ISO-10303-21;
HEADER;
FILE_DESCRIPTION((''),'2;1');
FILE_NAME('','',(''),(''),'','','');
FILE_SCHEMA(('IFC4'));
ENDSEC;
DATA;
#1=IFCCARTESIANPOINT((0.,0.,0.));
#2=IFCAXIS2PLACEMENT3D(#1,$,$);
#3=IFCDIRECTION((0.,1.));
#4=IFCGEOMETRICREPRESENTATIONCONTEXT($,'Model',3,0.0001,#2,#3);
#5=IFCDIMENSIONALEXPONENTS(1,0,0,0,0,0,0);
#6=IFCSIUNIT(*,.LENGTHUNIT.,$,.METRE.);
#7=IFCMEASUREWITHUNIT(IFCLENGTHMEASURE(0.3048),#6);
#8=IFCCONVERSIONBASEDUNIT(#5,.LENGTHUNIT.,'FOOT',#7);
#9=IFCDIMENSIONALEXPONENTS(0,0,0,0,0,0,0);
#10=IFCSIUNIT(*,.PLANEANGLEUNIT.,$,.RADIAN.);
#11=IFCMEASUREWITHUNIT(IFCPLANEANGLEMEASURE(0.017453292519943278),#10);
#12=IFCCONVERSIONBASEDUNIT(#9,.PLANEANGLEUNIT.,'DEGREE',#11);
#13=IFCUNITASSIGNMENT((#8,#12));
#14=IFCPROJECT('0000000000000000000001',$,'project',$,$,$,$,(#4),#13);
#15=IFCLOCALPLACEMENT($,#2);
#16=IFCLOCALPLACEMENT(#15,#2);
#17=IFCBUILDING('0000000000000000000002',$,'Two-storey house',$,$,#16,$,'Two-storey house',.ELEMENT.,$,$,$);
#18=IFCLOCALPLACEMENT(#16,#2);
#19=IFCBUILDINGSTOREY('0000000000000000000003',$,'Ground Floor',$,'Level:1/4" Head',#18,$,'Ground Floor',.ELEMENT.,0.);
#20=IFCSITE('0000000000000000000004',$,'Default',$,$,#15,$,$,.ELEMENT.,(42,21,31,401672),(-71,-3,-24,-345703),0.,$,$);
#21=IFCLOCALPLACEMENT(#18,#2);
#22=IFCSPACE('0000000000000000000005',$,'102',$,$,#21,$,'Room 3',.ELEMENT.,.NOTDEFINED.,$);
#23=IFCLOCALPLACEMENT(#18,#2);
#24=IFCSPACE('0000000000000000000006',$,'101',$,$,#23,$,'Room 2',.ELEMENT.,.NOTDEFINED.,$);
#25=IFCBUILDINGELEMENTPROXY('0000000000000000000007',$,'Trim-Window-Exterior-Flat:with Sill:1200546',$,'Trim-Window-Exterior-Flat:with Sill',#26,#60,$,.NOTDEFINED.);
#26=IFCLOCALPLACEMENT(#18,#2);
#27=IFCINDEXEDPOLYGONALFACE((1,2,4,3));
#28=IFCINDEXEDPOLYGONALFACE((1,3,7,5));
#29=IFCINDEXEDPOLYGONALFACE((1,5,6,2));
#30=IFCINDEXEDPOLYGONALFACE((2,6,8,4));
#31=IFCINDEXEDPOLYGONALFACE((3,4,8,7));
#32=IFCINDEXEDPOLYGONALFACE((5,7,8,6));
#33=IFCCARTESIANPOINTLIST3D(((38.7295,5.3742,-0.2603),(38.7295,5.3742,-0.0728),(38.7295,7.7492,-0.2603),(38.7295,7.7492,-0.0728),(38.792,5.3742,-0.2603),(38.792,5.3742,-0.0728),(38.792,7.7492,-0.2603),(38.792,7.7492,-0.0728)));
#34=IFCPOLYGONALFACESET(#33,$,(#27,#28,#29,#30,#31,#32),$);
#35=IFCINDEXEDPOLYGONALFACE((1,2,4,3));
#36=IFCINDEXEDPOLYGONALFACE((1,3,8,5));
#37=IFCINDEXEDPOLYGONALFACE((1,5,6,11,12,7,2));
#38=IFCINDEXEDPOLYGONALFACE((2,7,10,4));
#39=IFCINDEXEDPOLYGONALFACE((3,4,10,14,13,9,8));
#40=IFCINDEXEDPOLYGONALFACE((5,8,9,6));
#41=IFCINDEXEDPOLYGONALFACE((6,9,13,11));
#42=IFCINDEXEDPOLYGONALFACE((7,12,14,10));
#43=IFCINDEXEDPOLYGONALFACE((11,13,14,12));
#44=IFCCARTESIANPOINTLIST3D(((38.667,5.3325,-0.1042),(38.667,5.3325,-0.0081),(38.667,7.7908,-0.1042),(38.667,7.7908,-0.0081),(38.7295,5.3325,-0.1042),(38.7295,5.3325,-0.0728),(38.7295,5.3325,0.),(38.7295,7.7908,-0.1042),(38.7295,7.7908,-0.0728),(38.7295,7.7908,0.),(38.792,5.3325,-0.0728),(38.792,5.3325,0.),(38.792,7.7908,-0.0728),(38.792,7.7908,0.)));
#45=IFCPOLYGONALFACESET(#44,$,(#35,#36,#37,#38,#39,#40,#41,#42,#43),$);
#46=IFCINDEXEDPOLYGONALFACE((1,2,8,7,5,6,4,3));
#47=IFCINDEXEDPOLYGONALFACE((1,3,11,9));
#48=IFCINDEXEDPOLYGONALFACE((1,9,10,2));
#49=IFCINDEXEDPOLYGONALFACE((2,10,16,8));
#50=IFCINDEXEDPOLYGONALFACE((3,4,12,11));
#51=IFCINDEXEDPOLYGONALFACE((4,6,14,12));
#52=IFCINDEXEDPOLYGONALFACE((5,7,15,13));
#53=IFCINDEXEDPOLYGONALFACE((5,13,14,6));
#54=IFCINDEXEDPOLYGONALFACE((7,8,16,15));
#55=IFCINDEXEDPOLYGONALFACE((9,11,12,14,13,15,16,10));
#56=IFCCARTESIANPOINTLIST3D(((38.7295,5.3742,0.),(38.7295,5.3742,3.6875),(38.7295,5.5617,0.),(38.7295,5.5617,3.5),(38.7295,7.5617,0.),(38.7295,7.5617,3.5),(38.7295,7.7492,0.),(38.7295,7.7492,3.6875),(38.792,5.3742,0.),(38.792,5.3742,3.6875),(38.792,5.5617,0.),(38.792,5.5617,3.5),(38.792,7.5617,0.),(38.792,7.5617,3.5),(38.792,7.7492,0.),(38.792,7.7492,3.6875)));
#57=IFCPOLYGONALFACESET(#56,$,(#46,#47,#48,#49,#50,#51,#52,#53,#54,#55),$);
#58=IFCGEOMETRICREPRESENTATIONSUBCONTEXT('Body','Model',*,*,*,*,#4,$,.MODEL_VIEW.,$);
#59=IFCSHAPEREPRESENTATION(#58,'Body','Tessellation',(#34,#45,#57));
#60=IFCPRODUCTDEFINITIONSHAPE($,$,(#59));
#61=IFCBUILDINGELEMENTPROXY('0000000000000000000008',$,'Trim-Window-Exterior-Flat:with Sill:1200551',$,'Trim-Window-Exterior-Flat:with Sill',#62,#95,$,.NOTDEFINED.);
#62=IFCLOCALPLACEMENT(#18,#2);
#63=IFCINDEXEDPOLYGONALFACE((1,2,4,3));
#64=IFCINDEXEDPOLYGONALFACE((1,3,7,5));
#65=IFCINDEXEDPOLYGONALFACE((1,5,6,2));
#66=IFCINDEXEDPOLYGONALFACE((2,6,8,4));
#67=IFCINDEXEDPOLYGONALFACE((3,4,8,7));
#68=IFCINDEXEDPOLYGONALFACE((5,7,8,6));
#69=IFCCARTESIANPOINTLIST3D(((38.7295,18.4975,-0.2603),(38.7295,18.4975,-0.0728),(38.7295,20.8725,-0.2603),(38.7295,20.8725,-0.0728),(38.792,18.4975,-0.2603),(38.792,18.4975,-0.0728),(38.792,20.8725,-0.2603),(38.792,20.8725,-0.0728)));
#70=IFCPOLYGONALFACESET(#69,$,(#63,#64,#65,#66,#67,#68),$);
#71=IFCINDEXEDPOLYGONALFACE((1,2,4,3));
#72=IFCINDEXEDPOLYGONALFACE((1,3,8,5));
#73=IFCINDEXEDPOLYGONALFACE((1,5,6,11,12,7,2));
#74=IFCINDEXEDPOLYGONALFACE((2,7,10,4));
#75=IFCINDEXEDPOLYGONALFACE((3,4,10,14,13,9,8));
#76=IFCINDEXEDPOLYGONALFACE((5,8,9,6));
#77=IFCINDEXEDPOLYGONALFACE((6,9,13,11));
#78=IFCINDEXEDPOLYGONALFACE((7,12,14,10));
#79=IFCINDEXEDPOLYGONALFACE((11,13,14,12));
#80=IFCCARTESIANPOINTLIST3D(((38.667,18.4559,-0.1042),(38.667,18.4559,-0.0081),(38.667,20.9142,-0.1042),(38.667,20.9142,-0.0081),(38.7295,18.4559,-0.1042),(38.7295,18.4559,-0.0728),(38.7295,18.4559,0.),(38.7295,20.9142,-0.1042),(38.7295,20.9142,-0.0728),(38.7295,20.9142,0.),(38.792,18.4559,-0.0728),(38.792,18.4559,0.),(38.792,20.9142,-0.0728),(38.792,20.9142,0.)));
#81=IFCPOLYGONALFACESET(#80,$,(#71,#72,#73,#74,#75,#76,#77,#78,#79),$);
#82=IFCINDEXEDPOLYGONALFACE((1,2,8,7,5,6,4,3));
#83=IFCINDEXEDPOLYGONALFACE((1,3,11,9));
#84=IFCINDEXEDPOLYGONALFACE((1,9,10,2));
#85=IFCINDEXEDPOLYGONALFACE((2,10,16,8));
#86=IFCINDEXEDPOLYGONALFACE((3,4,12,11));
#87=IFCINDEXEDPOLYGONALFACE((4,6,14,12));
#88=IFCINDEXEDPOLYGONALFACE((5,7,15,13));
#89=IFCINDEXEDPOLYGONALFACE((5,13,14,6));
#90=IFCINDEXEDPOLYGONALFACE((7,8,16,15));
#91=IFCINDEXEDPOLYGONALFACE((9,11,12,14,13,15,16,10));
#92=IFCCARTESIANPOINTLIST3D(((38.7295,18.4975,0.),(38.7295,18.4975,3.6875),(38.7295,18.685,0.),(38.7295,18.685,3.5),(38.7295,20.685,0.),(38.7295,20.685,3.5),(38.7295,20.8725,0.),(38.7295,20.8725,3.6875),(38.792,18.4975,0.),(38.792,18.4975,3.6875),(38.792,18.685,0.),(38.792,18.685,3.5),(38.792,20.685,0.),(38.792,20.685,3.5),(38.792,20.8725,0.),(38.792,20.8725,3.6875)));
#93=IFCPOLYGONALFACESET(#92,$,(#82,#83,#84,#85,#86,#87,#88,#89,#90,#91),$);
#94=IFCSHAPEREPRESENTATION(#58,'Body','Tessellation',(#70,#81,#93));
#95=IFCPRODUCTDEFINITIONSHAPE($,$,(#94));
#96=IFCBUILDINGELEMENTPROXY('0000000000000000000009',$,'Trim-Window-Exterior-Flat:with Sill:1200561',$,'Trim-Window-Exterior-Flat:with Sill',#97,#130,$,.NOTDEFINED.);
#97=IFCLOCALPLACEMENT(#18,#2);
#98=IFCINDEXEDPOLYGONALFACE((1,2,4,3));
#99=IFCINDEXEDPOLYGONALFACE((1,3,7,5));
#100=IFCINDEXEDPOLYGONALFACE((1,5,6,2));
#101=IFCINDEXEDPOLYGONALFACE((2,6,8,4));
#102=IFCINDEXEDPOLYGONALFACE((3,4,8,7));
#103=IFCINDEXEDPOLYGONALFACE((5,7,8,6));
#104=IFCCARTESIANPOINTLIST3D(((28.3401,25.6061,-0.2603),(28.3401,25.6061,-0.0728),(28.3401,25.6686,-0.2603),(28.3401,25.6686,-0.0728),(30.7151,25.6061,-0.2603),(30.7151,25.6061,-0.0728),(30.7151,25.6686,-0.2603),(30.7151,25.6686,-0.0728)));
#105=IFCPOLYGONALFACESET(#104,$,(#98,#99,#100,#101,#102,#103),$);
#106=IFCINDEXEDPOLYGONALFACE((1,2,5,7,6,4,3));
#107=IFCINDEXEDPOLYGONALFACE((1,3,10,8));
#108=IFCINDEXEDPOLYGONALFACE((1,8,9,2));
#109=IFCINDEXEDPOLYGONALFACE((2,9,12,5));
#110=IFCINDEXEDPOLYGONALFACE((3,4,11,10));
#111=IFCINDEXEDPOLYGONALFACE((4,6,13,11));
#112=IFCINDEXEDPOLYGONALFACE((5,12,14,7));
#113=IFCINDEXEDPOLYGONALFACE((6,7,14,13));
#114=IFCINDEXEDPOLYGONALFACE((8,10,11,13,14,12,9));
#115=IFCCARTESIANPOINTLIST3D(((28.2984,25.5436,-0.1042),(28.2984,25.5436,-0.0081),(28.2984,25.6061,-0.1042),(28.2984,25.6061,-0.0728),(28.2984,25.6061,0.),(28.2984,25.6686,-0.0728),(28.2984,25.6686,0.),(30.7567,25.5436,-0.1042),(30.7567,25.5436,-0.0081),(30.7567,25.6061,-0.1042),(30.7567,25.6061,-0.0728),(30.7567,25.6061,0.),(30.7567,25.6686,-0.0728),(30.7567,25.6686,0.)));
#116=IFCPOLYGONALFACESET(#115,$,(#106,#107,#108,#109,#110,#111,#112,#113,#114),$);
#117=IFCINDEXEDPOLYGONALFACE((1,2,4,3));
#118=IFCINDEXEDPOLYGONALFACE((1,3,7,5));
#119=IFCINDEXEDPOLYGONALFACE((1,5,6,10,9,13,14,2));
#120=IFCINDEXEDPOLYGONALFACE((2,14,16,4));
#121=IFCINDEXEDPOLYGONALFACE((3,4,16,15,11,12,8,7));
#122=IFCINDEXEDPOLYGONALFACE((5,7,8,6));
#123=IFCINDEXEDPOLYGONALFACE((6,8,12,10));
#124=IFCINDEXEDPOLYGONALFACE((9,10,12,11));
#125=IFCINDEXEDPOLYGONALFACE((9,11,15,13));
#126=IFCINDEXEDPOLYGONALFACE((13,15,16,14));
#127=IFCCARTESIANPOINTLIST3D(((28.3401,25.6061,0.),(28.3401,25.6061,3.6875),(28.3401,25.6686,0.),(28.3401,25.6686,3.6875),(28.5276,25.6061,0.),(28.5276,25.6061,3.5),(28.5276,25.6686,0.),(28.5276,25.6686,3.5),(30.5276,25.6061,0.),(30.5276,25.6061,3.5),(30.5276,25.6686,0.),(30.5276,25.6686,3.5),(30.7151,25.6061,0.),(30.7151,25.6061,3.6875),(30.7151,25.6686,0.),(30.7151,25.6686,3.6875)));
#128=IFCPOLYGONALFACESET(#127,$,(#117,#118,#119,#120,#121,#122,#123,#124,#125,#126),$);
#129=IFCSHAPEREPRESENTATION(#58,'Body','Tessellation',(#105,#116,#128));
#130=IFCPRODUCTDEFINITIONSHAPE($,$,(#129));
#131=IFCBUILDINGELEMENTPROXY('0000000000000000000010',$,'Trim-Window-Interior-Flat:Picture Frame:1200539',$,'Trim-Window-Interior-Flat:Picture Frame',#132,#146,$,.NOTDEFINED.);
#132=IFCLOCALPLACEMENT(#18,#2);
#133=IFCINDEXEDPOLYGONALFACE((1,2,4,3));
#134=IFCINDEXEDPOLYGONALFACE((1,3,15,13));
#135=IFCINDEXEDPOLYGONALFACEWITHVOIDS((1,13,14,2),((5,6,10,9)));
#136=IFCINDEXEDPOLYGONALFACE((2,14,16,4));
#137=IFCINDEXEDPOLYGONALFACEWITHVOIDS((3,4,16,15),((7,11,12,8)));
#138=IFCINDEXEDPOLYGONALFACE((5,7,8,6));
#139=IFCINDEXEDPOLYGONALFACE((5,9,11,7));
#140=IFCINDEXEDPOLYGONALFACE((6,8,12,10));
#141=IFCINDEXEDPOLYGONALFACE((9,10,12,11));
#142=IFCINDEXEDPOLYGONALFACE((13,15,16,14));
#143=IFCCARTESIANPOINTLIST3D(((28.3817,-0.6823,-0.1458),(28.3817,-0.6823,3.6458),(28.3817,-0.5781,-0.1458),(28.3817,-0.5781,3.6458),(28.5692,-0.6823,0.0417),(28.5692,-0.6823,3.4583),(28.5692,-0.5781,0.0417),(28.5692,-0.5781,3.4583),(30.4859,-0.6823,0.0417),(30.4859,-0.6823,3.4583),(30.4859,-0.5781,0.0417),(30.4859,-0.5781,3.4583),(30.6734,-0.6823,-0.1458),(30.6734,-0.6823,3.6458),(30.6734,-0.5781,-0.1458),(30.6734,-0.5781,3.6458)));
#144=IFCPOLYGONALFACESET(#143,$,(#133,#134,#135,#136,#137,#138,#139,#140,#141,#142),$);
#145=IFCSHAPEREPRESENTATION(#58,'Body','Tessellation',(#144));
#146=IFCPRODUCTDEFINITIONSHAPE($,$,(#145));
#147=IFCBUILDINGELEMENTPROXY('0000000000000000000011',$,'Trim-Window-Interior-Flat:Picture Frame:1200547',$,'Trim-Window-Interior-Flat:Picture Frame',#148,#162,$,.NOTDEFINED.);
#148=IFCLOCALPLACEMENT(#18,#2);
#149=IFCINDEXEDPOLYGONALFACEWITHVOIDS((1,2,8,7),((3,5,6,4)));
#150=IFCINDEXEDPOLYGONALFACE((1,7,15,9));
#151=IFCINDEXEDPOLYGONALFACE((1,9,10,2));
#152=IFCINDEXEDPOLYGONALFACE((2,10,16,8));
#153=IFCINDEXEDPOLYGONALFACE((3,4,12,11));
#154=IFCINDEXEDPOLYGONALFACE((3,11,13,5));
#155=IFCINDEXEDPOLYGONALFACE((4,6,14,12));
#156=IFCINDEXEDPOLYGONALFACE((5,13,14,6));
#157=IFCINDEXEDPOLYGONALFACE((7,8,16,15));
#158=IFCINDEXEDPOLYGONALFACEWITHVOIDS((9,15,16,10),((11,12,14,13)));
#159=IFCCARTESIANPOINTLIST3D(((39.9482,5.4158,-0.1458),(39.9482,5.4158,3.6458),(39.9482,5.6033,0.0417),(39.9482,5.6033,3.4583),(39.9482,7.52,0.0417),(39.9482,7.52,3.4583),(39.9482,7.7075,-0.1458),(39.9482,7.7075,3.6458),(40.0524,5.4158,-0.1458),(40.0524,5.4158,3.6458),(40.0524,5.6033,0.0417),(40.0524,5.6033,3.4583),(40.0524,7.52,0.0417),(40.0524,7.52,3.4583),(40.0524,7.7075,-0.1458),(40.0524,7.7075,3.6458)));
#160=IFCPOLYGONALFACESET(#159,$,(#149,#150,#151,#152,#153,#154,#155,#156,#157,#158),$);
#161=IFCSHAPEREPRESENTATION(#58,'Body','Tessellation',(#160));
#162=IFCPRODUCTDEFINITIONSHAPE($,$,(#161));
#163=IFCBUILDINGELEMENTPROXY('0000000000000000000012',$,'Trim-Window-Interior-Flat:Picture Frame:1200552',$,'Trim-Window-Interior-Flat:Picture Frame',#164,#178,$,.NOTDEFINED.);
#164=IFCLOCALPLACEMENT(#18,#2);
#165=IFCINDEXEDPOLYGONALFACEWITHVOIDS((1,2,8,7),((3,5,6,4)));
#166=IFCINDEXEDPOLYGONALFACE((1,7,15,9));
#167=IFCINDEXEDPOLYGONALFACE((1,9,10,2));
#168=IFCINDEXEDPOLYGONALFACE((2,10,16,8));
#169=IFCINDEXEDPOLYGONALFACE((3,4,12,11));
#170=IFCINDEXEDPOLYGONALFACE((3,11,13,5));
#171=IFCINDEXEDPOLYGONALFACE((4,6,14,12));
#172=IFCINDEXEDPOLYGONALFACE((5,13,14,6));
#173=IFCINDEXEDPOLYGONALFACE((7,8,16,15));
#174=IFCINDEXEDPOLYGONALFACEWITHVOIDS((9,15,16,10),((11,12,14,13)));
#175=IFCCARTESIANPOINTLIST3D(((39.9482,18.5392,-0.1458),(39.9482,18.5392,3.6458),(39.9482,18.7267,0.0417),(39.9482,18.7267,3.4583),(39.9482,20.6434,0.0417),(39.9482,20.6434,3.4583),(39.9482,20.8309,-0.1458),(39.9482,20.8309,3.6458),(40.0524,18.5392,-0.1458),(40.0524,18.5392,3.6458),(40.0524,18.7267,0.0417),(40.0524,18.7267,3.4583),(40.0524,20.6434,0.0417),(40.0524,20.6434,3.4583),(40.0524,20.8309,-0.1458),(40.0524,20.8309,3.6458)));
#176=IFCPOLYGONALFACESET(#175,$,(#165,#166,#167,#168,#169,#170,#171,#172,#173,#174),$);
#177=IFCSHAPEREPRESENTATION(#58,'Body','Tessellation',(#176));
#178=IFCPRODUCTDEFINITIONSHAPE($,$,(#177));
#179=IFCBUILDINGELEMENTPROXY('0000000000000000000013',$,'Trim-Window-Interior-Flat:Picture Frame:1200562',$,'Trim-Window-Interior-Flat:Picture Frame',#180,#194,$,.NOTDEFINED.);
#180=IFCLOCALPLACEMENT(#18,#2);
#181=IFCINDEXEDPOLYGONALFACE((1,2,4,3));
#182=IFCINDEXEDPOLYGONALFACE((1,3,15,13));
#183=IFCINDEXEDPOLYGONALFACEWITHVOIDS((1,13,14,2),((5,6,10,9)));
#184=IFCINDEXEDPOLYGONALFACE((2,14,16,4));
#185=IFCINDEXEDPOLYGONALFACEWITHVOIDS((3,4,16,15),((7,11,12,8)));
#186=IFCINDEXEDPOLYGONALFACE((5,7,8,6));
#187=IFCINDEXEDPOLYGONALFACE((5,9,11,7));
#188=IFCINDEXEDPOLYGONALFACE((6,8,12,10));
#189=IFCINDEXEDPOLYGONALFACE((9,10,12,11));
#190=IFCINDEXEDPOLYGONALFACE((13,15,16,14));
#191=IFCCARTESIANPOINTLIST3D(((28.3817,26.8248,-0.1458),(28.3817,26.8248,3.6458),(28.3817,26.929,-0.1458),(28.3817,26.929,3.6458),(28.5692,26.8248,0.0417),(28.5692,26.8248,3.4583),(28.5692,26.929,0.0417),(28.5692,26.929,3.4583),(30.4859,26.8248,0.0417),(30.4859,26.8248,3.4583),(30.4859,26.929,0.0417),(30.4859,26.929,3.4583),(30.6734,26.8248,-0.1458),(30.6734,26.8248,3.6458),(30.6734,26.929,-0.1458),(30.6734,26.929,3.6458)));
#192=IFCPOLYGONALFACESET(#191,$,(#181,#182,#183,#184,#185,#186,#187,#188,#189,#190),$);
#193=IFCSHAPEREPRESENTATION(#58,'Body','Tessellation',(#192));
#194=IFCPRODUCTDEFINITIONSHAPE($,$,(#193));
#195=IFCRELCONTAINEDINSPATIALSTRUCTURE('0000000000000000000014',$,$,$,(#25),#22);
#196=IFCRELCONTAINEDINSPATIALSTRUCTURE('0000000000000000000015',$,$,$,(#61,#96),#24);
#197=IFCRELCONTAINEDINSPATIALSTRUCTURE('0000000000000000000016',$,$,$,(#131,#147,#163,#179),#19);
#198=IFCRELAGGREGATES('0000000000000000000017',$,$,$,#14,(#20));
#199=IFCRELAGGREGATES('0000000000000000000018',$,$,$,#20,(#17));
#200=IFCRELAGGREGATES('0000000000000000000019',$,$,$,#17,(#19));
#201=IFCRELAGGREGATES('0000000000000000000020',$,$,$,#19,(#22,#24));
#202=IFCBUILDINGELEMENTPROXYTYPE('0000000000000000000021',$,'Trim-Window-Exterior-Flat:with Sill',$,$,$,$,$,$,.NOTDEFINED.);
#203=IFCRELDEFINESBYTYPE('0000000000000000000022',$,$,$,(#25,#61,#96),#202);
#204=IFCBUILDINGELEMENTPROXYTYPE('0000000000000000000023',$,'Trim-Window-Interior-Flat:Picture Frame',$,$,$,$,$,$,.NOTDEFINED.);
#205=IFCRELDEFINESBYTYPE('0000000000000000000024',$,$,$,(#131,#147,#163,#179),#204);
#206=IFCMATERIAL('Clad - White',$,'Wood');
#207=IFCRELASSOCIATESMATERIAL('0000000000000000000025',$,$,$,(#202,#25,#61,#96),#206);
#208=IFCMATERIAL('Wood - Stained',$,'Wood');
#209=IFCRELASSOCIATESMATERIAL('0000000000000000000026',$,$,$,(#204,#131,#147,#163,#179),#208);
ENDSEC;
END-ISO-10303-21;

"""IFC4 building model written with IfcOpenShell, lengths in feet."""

from ifc_helpers import new_model, entity, si_unit, converted_unit, direction, frame, origin, place, context, subcontext, project, spatial, indexed_curve, outline, extrude, source, transform, mapped, material, type_object, type_shapes, element, save


model = new_model("IFC4")

# Units and contexts
model_context = context("Model", 3, precision=0.0001, world=origin(), true_north=direction((0.0, 1.0)))
body_context = subcontext(model_context, "Body", "Model", "MODEL_VIEW")
ifc_project = project(units=[converted_unit("LENGTHUNIT", "FOOT", entity("IfcLengthMeasure", 0.3048), si_unit("LENGTHUNIT", "METRE"), dimensions=[1, 0, 0, 0, 0, 0, 0]), converted_unit("PLANEANGLEUNIT", "DEGREE", entity("IfcPlaneAngleMeasure", 0.017453292519943278), si_unit("PLANEANGLEUNIT", "RADIAN"), dimensions=[0, 0, 0, 0, 0, 0, 0])], contexts=[model_context])

# Site, building, storey
site_placement = place(None, origin())
site = spatial("IfcSite", under=ifc_project, at=site_placement, Name="Default", CompositionType="ELEMENT", RefLatitude=(42, 21, 31, 401672), RefLongitude=(-71, -3, -24, -345703), RefElevation=0.0)
building_placement = place(site_placement, origin())
building = spatial("IfcBuilding", under=site, at=building_placement, Name="Two-storey house", LongName="Two-storey house", CompositionType="ELEMENT")
storey_placement = place(building_placement, origin())
storey = spatial("IfcBuildingStorey", under=building, at=storey_placement, Name="Ground Floor", ObjectType="Level:1/4\" Head", LongName="Ground Floor", CompositionType="ELEMENT", Elevation=0.0)

# Shared definitions
ifc_material_1 = material(Name="Wood - Stained", Category="Wood")

# Shared definitions
ifc_material_2 = material(Name="Clad - White", Category="Wood")

# Shared definitions
space_1_placement = place(storey_placement, origin())
space_1 = spatial("IfcSpace", under=storey, at=space_1_placement, Name="102", LongName="Room 3", CompositionType="ELEMENT", PredefinedType="NOTDEFINED")

# Building element proxy
building_element_proxy_type_1 = type_object("IfcBuildingElementProxyType", Name="Trim-Window-Exterior-Flat:with Sill", PredefinedType="NOTDEFINED", material=ifc_material_2)
shared_shape_1 = source(origin(), body_context, "Body", "SweptSolid", [
    extrude(outline(indexed_curve([(-1.1875, -0.0938), (1.1875, -0.0938), (1.1875, 0.0938), (-1.1875, 0.0938), (-1.1875, -0.0938)], self_intersect=False)), frame((0.0, -3.6665, 0.0), z_axis=(0.0, 0.0, 1.0), x_axis=(-1.0, 0.0, 0.0)), (0.0, 0.0, 1.0), 0.0625),
    extrude(outline(indexed_curve([(-0.0625, -0.0525), (0.0, -0.0525), (0.0, -0.0211), (0.0625, -0.0211), (0.0625, 0.0517), (0.0, 0.0517), (-0.0625, 0.0436), (-0.0625, -0.0525)], self_intersect=False)), frame((-1.2292, -3.5517, 0.0625), z_axis=(1.0, 0.0, 0.0), x_axis=(0.0, 0.0, -1.0)), (0.0, 0.0, 1.0), 2.4583),
    extrude(outline(indexed_curve([(-1.8906, -1.1875), (1.7969, -1.1875), (1.7969, -1.0), (-1.7031, -1.0), (-1.7031, 1.0), (1.7969, 1.0), (1.7969, 1.1875), (-1.8906, 1.1875), (-1.8906, -1.1875)], self_intersect=False)), frame((0.0, -1.7031, 0.0), z_axis=(0.0, 0.0, 1.0), x_axis=(0.0, -1.0, 0.0)), (0.0, 0.0, 1.0), 0.0625),
])
type_shapes(building_element_proxy_type_1, [shared_shape_1])
for number, where, z_axis, x_axis, name in (
    (1, (38.792, 6.5617, 3.5), (-1.0, 0.0, 0.0), (0.0, -1.0, 0.0), "Trim-Window-Exterior-Flat:with Sill:1200546"),
):
    element("IfcBuildingElementProxy", number, at=place(space_1_placement, frame(where, z_axis=z_axis, x_axis=x_axis)), inside=space_1, type_object=building_element_proxy_type_1, material=ifc_material_2, Name=name, ObjectType="Trim-Window-Exterior-Flat:with Sill", PredefinedType="NOTDEFINED", context=body_context, shape_type="MappedRepresentation", body=[
        mapped(shared_shape_1, transform((0.0, 0.0, 0.0), scale=1.0)),
    ])

# Shared definitions
space_2_placement = place(storey_placement, origin())
space_2 = spatial("IfcSpace", under=storey, at=space_2_placement, Name="101", LongName="Room 2", CompositionType="ELEMENT", PredefinedType="NOTDEFINED")

# Building element proxies
for number, where, z_axis, x_axis, name in (
    (2, (38.792, 19.685, 3.5), (-1.0, 0.0, 0.0), (0.0, -1.0, 0.0), "Trim-Window-Exterior-Flat:with Sill:1200551"),
    (3, (29.5276, 25.6686, 3.5), (0.0, -1.0, 0.0), (1.0, 0.0, 0.0), "Trim-Window-Exterior-Flat:with Sill:1200561"),
):
    element("IfcBuildingElementProxy", number, at=place(space_2_placement, frame(where, z_axis=z_axis, x_axis=x_axis)), inside=space_2, type_object=building_element_proxy_type_1, material=ifc_material_2, Name=name, ObjectType="Trim-Window-Exterior-Flat:with Sill", PredefinedType="NOTDEFINED", context=body_context, shape_type="MappedRepresentation", body=[
        mapped(shared_shape_1, transform((0.0, 0.0, 0.0), scale=1.0)),
    ])
building_element_proxy_type_2 = type_object("IfcBuildingElementProxyType", Name="Trim-Window-Interior-Flat:Picture Frame", PredefinedType="NOTDEFINED", material=ifc_material_1)
shared_shape_2 = source(origin(), body_context, "Body", "SweptSolid", [
    extrude(outline(indexed_curve([(-1.1458, -1.8958), (1.1458, -1.8958), (1.1458, 1.8958), (-1.1458, 1.8958), (-1.1458, -1.8958)], self_intersect=False), holes=[indexed_curve([(-0.9583, -1.7083), (-0.9583, 1.7083), (0.9583, 1.7083), (0.9583, -1.7083), (-0.9583, -1.7083)], self_intersect=False)]), frame((0.0, -1.75, 0.0), z_axis=(0.0, 0.0, 1.0), x_axis=(-1.0, 0.0, 0.0)), (0.0, 0.0, 1.0), 0.1042),
])
type_shapes(building_element_proxy_type_2, [shared_shape_2])
for number, where, z_axis, x_axis, name in (
    (4, (29.5276, -0.5781, 3.5), (0.0, -1.0, 0.0), (1.0, 0.0, 0.0), "Trim-Window-Interior-Flat:Picture Frame:1200539"),
    (5, (39.9482, 6.5617, 3.5), (1.0, 0.0, 0.0), (0.0, 1.0, 0.0), "Trim-Window-Interior-Flat:Picture Frame:1200547"),
    (6, (39.9482, 19.685, 3.5), (1.0, 0.0, 0.0), (0.0, 1.0, 0.0), "Trim-Window-Interior-Flat:Picture Frame:1200552"),
    (7, (29.5276, 26.8248, 3.5), (0.0, 1.0, 0.0), (-1.0, 0.0, 0.0), "Trim-Window-Interior-Flat:Picture Frame:1200562"),
):
    element("IfcBuildingElementProxy", number, at=place(storey_placement, frame(where, z_axis=z_axis, x_axis=x_axis)), inside=storey, type_object=building_element_proxy_type_2, material=ifc_material_1, Name=name, ObjectType="Trim-Window-Interior-Flat:Picture Frame", PredefinedType="NOTDEFINED", context=body_context, shape_type="MappedRepresentation", body=[
        mapped(shared_shape_2, transform((0.0, 0.0, 0.0), scale=1.0)),
    ])

save(model, "model.ifc")
